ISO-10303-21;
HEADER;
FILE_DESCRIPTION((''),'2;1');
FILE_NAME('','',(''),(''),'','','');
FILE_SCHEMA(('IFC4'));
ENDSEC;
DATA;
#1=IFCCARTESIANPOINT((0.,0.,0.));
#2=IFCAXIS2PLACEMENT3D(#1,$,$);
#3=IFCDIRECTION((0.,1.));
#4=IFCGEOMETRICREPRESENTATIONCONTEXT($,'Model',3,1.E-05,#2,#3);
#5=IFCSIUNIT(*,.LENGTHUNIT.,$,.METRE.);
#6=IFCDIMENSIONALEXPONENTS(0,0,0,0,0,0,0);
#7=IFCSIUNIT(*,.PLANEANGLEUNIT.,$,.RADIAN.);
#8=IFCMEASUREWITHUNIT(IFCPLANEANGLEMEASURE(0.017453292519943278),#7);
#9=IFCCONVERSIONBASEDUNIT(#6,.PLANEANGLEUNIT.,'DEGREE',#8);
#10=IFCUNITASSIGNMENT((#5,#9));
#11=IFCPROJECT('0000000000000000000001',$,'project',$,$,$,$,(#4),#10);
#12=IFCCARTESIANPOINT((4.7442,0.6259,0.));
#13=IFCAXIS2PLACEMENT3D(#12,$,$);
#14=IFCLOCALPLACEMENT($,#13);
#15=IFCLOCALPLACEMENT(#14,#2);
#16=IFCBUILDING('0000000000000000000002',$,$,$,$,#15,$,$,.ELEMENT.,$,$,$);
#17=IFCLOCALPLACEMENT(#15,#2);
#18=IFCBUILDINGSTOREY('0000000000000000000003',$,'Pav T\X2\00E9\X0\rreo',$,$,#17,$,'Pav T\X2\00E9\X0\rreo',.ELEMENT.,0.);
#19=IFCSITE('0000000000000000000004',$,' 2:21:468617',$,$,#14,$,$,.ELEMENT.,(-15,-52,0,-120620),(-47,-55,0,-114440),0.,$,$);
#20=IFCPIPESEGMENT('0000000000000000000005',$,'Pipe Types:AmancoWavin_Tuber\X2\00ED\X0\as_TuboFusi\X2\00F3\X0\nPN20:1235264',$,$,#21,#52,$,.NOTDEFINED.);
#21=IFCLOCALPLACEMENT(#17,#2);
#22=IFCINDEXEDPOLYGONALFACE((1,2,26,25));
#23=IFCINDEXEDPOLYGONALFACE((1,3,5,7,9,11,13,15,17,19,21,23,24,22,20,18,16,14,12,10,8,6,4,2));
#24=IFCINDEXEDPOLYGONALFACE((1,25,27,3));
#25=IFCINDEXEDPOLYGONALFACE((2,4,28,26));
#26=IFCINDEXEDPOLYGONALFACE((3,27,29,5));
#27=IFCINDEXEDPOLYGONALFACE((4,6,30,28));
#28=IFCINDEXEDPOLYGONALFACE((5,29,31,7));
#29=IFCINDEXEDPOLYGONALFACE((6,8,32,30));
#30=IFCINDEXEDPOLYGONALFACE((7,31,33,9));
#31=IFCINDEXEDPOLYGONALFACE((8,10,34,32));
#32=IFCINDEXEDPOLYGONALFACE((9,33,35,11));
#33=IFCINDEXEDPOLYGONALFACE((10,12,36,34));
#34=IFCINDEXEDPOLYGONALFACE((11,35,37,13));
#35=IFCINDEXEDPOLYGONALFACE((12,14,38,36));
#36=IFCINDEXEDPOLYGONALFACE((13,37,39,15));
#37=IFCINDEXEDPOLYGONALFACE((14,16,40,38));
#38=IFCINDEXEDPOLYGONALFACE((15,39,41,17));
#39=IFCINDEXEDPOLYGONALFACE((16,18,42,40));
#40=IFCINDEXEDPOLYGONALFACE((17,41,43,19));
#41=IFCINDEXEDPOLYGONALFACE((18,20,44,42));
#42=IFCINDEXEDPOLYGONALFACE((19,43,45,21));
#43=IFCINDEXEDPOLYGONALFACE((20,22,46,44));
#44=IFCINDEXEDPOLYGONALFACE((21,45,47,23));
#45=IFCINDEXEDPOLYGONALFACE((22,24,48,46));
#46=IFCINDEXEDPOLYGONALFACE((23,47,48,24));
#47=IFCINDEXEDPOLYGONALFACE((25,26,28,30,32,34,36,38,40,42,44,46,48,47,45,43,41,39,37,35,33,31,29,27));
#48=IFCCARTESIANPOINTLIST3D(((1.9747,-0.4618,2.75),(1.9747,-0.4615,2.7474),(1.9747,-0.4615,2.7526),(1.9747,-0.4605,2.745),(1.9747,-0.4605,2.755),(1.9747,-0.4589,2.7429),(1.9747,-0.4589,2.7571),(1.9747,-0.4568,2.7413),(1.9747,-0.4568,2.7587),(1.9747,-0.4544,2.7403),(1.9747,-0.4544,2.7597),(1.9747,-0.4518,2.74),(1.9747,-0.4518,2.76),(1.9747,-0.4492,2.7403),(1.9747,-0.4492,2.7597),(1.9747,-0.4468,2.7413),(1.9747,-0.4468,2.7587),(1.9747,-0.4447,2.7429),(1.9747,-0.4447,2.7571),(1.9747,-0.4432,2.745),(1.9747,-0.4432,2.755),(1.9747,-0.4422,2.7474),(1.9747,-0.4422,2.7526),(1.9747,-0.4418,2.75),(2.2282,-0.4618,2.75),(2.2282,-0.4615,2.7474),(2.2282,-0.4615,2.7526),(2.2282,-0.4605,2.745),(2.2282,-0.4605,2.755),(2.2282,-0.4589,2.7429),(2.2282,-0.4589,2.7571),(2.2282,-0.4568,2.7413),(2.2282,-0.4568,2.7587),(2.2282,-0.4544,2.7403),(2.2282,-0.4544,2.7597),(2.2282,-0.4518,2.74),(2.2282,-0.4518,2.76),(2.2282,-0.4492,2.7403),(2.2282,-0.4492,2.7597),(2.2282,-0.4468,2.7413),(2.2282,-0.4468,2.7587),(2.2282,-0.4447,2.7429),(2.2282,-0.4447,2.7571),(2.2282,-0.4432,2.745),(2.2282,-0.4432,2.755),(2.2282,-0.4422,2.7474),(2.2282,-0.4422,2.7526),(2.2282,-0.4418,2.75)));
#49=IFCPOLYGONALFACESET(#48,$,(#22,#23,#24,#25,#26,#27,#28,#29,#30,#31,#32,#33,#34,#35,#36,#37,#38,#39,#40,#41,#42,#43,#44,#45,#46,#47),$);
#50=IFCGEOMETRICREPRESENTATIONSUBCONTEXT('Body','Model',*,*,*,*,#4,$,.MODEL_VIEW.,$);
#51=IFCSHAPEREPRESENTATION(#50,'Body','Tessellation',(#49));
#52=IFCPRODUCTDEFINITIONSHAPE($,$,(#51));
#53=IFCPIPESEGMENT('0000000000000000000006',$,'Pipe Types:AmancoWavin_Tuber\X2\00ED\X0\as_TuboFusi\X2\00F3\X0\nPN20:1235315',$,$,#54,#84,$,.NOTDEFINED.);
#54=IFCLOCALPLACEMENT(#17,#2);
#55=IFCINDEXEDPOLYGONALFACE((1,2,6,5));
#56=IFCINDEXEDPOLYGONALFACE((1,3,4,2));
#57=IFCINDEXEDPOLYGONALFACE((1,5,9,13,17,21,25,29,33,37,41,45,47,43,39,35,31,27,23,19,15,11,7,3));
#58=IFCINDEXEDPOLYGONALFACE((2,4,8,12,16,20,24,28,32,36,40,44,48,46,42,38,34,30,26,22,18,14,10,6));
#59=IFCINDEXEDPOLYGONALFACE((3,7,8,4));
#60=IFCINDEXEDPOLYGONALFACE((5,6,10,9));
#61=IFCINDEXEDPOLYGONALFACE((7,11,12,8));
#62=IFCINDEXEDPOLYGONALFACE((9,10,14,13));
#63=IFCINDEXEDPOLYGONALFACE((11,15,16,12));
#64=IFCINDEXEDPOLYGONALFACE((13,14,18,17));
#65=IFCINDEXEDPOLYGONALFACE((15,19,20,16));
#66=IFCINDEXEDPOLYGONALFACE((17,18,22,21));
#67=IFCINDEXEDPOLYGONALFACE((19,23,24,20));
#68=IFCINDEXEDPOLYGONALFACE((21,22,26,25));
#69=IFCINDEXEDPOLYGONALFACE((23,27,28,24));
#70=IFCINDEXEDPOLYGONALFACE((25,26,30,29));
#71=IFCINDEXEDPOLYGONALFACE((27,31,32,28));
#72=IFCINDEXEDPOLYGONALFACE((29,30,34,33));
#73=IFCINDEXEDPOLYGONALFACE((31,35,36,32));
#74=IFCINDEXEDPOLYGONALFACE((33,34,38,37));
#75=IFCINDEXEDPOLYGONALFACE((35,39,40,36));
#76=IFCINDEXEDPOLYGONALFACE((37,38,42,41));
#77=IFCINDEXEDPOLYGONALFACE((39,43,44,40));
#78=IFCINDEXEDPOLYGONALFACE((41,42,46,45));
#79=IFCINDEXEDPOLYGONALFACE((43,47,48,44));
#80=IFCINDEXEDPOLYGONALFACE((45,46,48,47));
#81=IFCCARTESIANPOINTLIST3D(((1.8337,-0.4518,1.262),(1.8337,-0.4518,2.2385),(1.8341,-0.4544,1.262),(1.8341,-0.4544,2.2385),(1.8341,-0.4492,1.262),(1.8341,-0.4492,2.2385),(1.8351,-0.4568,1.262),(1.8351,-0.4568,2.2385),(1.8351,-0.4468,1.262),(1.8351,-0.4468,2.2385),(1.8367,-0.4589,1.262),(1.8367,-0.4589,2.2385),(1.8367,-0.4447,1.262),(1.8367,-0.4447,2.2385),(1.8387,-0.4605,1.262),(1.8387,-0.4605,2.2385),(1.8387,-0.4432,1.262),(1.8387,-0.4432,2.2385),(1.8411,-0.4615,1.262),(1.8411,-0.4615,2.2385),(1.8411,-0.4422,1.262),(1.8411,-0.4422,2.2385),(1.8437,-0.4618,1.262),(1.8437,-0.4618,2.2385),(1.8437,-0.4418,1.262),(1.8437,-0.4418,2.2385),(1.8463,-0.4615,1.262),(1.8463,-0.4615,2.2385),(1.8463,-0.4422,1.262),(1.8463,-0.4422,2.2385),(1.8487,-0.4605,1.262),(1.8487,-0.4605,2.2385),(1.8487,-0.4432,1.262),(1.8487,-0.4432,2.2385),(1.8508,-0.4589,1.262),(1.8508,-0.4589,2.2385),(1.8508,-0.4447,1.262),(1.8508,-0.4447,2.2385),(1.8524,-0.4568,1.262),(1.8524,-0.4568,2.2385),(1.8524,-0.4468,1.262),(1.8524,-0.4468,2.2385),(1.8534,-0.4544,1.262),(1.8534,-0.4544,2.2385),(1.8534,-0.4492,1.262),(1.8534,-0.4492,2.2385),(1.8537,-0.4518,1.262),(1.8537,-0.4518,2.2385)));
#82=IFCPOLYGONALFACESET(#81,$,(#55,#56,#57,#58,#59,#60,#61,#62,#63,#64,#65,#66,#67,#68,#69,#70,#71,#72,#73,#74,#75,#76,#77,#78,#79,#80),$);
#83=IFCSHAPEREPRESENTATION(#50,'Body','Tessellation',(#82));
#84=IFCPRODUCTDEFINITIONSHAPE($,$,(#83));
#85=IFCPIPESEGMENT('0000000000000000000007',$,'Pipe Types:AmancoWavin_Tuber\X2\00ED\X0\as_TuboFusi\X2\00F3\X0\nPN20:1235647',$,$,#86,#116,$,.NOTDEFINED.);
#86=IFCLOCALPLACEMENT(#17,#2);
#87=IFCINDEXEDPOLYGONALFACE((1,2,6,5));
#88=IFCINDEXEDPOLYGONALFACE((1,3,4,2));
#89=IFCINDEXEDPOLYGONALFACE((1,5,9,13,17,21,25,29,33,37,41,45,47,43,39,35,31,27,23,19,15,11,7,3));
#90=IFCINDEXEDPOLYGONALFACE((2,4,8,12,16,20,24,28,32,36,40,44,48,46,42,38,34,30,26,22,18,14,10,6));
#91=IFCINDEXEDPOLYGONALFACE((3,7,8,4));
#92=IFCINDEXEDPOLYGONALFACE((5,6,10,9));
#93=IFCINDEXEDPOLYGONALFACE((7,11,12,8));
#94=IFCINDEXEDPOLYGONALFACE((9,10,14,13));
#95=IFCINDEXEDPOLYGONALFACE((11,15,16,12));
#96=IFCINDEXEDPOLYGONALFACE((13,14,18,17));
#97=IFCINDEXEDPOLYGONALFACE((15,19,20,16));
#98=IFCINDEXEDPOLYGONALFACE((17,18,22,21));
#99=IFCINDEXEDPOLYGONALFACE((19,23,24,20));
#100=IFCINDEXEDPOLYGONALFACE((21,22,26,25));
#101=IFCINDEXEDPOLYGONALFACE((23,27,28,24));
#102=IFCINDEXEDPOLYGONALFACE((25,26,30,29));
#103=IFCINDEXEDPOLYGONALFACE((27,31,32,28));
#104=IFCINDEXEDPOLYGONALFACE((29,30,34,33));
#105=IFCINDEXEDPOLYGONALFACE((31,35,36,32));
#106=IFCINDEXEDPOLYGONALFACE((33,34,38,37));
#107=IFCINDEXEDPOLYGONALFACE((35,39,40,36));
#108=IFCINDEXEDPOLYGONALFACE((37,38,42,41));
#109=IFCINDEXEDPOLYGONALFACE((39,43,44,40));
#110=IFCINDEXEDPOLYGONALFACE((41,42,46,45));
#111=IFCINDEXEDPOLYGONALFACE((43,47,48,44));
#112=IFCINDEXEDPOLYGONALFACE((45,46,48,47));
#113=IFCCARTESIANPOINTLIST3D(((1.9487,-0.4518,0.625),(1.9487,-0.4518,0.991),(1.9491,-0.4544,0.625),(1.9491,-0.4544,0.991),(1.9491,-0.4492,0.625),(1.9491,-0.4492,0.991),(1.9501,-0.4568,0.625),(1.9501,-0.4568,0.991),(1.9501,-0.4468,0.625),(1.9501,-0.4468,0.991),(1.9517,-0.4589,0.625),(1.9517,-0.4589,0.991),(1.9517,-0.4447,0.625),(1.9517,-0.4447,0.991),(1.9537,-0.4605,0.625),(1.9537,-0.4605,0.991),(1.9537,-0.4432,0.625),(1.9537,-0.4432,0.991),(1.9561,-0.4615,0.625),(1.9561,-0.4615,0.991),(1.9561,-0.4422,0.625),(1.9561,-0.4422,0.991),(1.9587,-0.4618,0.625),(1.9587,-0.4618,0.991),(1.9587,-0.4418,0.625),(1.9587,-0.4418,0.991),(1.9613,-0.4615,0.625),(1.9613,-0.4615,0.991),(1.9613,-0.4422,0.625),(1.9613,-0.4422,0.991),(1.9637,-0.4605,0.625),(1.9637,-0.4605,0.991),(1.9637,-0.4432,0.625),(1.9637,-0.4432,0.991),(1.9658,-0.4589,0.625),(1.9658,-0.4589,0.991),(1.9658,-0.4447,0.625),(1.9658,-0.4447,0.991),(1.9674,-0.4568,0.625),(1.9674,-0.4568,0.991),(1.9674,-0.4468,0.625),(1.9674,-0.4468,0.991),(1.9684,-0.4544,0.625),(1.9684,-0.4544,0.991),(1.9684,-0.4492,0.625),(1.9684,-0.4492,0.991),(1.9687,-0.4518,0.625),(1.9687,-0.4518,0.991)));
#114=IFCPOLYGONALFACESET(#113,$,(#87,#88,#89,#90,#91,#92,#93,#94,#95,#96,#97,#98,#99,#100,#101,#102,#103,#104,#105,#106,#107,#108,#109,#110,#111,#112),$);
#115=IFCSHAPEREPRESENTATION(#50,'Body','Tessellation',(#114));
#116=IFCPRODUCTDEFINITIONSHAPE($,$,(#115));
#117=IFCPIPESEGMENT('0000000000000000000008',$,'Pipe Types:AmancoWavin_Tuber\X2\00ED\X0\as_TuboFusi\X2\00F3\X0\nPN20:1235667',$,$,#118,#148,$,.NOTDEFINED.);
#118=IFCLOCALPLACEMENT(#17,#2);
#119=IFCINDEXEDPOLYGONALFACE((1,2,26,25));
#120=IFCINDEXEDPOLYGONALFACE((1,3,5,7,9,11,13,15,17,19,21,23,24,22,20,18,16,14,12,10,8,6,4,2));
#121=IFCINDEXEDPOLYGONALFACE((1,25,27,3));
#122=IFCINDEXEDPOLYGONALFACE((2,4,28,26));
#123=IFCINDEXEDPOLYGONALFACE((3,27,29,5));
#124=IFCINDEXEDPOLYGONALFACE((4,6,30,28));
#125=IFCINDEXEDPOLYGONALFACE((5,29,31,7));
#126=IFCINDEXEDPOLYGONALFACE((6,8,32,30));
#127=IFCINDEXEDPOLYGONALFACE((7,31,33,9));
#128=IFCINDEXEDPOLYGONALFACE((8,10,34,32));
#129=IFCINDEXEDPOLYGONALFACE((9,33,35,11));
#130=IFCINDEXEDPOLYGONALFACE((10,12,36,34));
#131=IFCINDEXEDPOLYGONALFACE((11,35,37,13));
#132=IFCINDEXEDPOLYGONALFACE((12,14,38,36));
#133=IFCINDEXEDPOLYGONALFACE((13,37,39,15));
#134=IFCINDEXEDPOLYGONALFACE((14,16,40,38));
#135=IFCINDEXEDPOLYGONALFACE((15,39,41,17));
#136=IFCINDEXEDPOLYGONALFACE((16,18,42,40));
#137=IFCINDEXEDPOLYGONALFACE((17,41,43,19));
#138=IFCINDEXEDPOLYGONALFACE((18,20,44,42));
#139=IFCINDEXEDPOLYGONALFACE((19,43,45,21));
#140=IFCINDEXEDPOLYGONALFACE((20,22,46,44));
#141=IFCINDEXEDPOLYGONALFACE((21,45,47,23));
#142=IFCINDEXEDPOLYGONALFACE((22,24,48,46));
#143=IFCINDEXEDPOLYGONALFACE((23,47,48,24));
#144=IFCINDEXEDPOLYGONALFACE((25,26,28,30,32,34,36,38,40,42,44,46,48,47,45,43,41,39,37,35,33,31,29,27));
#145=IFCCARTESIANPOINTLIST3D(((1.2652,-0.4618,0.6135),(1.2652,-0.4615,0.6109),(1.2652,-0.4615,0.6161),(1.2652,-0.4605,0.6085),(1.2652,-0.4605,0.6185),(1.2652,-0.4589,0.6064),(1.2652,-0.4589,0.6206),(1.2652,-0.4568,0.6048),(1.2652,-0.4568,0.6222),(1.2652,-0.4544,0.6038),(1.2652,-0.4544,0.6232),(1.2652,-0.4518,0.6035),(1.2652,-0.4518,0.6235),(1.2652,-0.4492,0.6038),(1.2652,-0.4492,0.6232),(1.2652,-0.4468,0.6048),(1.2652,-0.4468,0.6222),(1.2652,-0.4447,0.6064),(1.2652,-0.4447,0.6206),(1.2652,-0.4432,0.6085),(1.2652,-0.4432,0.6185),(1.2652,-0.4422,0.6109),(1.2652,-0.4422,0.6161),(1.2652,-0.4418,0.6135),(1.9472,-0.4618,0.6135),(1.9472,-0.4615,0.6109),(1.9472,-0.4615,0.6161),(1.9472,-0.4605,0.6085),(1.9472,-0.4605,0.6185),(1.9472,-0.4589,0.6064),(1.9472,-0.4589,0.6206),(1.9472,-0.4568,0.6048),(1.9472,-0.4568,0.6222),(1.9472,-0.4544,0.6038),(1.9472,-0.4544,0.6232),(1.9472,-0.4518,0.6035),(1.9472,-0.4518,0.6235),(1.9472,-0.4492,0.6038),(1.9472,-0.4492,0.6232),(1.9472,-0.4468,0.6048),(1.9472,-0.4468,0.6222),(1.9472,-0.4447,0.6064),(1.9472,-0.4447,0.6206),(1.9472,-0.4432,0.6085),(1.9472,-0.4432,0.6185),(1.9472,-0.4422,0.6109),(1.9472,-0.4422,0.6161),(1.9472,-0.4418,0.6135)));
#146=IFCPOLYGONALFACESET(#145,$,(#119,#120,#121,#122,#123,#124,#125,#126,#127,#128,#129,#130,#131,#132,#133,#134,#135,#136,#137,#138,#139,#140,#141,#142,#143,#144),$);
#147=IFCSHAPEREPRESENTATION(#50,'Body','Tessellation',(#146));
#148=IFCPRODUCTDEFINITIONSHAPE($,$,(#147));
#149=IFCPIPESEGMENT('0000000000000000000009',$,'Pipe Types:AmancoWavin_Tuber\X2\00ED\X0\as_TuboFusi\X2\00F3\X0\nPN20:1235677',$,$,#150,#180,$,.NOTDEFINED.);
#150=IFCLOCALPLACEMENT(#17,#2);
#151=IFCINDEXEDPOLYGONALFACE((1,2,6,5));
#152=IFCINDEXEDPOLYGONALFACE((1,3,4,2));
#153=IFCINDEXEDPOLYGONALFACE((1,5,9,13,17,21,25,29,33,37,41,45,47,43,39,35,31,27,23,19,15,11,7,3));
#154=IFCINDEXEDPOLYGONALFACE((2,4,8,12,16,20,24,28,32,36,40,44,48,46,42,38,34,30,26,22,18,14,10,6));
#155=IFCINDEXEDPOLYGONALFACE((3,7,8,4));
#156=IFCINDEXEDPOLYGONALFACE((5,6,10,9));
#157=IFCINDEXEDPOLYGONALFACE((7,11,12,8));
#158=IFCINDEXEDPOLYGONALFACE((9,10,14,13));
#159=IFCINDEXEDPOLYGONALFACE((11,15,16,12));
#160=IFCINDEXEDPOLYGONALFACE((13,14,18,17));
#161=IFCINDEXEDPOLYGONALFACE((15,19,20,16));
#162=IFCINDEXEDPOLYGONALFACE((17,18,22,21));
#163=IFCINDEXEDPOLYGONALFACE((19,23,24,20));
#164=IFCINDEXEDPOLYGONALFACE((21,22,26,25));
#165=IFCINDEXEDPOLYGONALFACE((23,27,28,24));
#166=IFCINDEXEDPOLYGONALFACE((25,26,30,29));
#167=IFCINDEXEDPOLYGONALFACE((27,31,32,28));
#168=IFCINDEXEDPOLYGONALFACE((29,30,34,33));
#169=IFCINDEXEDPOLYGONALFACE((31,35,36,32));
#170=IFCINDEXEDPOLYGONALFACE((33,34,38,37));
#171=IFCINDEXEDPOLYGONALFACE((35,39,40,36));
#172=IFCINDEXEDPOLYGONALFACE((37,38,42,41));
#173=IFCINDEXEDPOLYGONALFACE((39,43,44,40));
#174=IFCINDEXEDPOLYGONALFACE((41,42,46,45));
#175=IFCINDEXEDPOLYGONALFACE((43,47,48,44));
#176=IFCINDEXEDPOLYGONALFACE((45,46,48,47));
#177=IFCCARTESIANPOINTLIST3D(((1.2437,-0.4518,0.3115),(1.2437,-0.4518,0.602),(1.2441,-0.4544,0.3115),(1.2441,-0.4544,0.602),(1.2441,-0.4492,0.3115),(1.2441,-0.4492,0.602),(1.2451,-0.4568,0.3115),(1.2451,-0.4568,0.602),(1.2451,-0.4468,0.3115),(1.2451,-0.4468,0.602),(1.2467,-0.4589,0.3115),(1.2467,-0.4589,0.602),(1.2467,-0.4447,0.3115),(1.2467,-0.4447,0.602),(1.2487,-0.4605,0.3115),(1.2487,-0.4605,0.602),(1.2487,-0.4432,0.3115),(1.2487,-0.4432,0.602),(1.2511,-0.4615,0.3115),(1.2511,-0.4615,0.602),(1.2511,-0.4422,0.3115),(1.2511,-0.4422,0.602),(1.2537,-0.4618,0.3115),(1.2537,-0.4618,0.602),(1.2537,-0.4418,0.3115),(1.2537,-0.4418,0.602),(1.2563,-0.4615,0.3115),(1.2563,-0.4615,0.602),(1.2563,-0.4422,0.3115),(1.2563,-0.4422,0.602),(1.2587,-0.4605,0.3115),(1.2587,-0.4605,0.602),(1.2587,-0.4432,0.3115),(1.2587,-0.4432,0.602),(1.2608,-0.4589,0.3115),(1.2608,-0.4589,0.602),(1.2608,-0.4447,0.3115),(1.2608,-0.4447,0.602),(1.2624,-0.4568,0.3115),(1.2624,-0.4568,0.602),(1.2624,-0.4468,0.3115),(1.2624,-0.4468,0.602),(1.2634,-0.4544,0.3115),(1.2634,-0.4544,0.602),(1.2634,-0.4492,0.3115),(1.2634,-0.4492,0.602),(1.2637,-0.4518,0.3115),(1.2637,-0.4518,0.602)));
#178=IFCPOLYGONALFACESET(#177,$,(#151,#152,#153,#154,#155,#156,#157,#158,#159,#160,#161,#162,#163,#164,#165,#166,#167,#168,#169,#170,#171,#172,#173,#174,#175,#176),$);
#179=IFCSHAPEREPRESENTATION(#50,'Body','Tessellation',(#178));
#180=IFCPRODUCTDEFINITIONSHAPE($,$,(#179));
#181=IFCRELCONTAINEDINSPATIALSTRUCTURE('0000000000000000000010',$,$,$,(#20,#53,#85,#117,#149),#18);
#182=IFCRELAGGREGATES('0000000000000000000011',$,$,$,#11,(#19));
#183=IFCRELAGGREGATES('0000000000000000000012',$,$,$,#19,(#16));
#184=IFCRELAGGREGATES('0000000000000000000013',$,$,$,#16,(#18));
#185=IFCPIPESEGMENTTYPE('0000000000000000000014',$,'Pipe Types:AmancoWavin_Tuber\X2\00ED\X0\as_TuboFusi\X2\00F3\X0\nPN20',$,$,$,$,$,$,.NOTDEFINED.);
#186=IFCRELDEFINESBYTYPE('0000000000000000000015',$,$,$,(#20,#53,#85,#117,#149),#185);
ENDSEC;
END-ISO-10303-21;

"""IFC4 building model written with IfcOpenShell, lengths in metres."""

from ifc_helpers import new_model, entity, si_unit, converted_unit, direction, frame, origin, place, context, subcontext, project, spatial, arc, indexed_curve, outline, extrude, type_object, element, save


model = new_model("IFC4")

# Units and contexts
model_context = context("Model", 3, precision=1e-05, world=origin(), true_north=direction((0.0, 1.0)))
body_context = subcontext(model_context, "Body", "Model", "MODEL_VIEW")
ifc_project = project(units=[si_unit("LENGTHUNIT", "METRE"), converted_unit("PLANEANGLEUNIT", "DEGREE", entity("IfcPlaneAngleMeasure", 0.017453292519943278), si_unit("PLANEANGLEUNIT", "RADIAN"), dimensions=[0, 0, 0, 0, 0, 0, 0])], contexts=[model_context])

# Site, building, storey
site_placement = place(None, frame((4.7442, 0.6259, 0.0)))
site = spatial("IfcSite", under=ifc_project, at=site_placement, Name=" 2:21:468617", CompositionType="ELEMENT", RefLatitude=(-15, -52, 0, -120620), RefLongitude=(-47, -55, 0, -114440), RefElevation=0.0)
building_placement = place(site_placement, origin())
building = spatial("IfcBuilding", under=site, at=building_placement, CompositionType="ELEMENT")
storey_placement = place(building_placement, origin())
storey = spatial("IfcBuildingStorey", under=building, at=storey_placement, Name="Pav Térreo", LongName="Pav Térreo", CompositionType="ELEMENT", Elevation=0.0)

# Pipe segments
pipe_segment_type_1 = type_object("IfcPipeSegmentType", Name="Pipe Types:AmancoWavin_Tuberías_TuboFusiónPN20", PredefinedType="NOTDEFINED")
pipe_segment_1_placement = place(storey_placement, origin())
element("IfcPipeSegment", 1, at=pipe_segment_1_placement, inside=storey, type_object=pipe_segment_type_1, Name="Pipe Types:AmancoWavin_Tuberías_TuboFusiónPN20:1235264", PredefinedType="NOTDEFINED", context=body_context, shape_type="SweptSolid", body=[
    extrude(outline(indexed_curve([(0.01, 0.0), (0.0071, 0.0071), (0.0, 0.01), (-0.0071, 0.0071), (-0.01, 0.0), (-0.0071, -0.0071), (0.0, -0.01), (0.0071, -0.0071)], segments=[arc(1, 2, 3), arc(3, 4, 5), arc(5, 6, 7), arc(7, 8, 1)], self_intersect=False)), frame((1.9747, -0.4518, 2.75), z_axis=(1.0, 0.0, 0.0), x_axis=(0.0, -1.0, 0.0)), (0.0, 0.0, 1.0), 0.2535),
])
pipe_segment_2_placement = place(storey_placement, origin())
element("IfcPipeSegment", 2, at=pipe_segment_2_placement, inside=storey, type_object=pipe_segment_type_1, Name="Pipe Types:AmancoWavin_Tuberías_TuboFusiónPN20:1235315", PredefinedType="NOTDEFINED", context=body_context, shape_type="SweptSolid", body=[
    extrude(outline(indexed_curve([(0.01, 0.0), (0.0071, 0.0071), (0.0, 0.01), (-0.0071, 0.0071), (-0.01, 0.0), (-0.0071, -0.0071), (0.0, -0.01), (0.0071, -0.0071)], segments=[arc(1, 2, 3), arc(3, 4, 5), arc(5, 6, 7), arc(7, 8, 1)], self_intersect=False)), frame((1.8437, -0.4518, 1.262), z_axis=(0.0, 0.0, 1.0), x_axis=(-1.0, 0.0, 0.0)), (0.0, 0.0, 1.0), 0.9765),
])
pipe_segment_3_placement = place(storey_placement, origin())
element("IfcPipeSegment", 3, at=pipe_segment_3_placement, inside=storey, type_object=pipe_segment_type_1, Name="Pipe Types:AmancoWavin_Tuberías_TuboFusiónPN20:1235647", PredefinedType="NOTDEFINED", context=body_context, shape_type="SweptSolid", body=[
    extrude(outline(indexed_curve([(0.01, 0.0), (0.0071, 0.0071), (0.0, 0.01), (-0.0071, 0.0071), (-0.01, 0.0), (-0.0071, -0.0071), (0.0, -0.01), (0.0071, -0.0071)], segments=[arc(1, 2, 3), arc(3, 4, 5), arc(5, 6, 7), arc(7, 8, 1)], self_intersect=False)), frame((1.9587, -0.4518, 0.625)), (0.0, 0.0, 1.0), 0.366),
])
pipe_segment_4_placement = place(storey_placement, origin())
element("IfcPipeSegment", 4, at=pipe_segment_4_placement, inside=storey, type_object=pipe_segment_type_1, Name="Pipe Types:AmancoWavin_Tuberías_TuboFusiónPN20:1235667", PredefinedType="NOTDEFINED", context=body_context, shape_type="SweptSolid", body=[
    extrude(outline(indexed_curve([(0.01, 0.0), (0.0071, 0.0071), (0.0, 0.01), (-0.0071, 0.0071), (-0.01, 0.0), (-0.0071, -0.0071), (0.0, -0.01), (0.0071, -0.0071)], segments=[arc(1, 2, 3), arc(3, 4, 5), arc(5, 6, 7), arc(7, 8, 1)], self_intersect=False)), frame((1.2652, -0.4518, 0.6135), z_axis=(1.0, 0.0, 0.0), x_axis=(0.0, 1.0, 0.0)), (0.0, 0.0, 1.0), 0.682),
])
pipe_segment_5_placement = place(storey_placement, origin())
element("IfcPipeSegment", 5, at=pipe_segment_5_placement, inside=storey, type_object=pipe_segment_type_1, Name="Pipe Types:AmancoWavin_Tuberías_TuboFusiónPN20:1235677", PredefinedType="NOTDEFINED", context=body_context, shape_type="SweptSolid", body=[
    extrude(outline(indexed_curve([(0.01, 0.0), (0.0071, 0.0071), (0.0, 0.01), (-0.0071, 0.0071), (-0.01, 0.0), (-0.0071, -0.0071), (0.0, -0.01), (0.0071, -0.0071)], segments=[arc(1, 2, 3), arc(3, 4, 5), arc(5, 6, 7), arc(7, 8, 1)], self_intersect=False)), frame((1.2537, -0.4518, 0.3115)), (0.0, 0.0, 1.0), 0.2905),
])

save(model, "model.ifc")
